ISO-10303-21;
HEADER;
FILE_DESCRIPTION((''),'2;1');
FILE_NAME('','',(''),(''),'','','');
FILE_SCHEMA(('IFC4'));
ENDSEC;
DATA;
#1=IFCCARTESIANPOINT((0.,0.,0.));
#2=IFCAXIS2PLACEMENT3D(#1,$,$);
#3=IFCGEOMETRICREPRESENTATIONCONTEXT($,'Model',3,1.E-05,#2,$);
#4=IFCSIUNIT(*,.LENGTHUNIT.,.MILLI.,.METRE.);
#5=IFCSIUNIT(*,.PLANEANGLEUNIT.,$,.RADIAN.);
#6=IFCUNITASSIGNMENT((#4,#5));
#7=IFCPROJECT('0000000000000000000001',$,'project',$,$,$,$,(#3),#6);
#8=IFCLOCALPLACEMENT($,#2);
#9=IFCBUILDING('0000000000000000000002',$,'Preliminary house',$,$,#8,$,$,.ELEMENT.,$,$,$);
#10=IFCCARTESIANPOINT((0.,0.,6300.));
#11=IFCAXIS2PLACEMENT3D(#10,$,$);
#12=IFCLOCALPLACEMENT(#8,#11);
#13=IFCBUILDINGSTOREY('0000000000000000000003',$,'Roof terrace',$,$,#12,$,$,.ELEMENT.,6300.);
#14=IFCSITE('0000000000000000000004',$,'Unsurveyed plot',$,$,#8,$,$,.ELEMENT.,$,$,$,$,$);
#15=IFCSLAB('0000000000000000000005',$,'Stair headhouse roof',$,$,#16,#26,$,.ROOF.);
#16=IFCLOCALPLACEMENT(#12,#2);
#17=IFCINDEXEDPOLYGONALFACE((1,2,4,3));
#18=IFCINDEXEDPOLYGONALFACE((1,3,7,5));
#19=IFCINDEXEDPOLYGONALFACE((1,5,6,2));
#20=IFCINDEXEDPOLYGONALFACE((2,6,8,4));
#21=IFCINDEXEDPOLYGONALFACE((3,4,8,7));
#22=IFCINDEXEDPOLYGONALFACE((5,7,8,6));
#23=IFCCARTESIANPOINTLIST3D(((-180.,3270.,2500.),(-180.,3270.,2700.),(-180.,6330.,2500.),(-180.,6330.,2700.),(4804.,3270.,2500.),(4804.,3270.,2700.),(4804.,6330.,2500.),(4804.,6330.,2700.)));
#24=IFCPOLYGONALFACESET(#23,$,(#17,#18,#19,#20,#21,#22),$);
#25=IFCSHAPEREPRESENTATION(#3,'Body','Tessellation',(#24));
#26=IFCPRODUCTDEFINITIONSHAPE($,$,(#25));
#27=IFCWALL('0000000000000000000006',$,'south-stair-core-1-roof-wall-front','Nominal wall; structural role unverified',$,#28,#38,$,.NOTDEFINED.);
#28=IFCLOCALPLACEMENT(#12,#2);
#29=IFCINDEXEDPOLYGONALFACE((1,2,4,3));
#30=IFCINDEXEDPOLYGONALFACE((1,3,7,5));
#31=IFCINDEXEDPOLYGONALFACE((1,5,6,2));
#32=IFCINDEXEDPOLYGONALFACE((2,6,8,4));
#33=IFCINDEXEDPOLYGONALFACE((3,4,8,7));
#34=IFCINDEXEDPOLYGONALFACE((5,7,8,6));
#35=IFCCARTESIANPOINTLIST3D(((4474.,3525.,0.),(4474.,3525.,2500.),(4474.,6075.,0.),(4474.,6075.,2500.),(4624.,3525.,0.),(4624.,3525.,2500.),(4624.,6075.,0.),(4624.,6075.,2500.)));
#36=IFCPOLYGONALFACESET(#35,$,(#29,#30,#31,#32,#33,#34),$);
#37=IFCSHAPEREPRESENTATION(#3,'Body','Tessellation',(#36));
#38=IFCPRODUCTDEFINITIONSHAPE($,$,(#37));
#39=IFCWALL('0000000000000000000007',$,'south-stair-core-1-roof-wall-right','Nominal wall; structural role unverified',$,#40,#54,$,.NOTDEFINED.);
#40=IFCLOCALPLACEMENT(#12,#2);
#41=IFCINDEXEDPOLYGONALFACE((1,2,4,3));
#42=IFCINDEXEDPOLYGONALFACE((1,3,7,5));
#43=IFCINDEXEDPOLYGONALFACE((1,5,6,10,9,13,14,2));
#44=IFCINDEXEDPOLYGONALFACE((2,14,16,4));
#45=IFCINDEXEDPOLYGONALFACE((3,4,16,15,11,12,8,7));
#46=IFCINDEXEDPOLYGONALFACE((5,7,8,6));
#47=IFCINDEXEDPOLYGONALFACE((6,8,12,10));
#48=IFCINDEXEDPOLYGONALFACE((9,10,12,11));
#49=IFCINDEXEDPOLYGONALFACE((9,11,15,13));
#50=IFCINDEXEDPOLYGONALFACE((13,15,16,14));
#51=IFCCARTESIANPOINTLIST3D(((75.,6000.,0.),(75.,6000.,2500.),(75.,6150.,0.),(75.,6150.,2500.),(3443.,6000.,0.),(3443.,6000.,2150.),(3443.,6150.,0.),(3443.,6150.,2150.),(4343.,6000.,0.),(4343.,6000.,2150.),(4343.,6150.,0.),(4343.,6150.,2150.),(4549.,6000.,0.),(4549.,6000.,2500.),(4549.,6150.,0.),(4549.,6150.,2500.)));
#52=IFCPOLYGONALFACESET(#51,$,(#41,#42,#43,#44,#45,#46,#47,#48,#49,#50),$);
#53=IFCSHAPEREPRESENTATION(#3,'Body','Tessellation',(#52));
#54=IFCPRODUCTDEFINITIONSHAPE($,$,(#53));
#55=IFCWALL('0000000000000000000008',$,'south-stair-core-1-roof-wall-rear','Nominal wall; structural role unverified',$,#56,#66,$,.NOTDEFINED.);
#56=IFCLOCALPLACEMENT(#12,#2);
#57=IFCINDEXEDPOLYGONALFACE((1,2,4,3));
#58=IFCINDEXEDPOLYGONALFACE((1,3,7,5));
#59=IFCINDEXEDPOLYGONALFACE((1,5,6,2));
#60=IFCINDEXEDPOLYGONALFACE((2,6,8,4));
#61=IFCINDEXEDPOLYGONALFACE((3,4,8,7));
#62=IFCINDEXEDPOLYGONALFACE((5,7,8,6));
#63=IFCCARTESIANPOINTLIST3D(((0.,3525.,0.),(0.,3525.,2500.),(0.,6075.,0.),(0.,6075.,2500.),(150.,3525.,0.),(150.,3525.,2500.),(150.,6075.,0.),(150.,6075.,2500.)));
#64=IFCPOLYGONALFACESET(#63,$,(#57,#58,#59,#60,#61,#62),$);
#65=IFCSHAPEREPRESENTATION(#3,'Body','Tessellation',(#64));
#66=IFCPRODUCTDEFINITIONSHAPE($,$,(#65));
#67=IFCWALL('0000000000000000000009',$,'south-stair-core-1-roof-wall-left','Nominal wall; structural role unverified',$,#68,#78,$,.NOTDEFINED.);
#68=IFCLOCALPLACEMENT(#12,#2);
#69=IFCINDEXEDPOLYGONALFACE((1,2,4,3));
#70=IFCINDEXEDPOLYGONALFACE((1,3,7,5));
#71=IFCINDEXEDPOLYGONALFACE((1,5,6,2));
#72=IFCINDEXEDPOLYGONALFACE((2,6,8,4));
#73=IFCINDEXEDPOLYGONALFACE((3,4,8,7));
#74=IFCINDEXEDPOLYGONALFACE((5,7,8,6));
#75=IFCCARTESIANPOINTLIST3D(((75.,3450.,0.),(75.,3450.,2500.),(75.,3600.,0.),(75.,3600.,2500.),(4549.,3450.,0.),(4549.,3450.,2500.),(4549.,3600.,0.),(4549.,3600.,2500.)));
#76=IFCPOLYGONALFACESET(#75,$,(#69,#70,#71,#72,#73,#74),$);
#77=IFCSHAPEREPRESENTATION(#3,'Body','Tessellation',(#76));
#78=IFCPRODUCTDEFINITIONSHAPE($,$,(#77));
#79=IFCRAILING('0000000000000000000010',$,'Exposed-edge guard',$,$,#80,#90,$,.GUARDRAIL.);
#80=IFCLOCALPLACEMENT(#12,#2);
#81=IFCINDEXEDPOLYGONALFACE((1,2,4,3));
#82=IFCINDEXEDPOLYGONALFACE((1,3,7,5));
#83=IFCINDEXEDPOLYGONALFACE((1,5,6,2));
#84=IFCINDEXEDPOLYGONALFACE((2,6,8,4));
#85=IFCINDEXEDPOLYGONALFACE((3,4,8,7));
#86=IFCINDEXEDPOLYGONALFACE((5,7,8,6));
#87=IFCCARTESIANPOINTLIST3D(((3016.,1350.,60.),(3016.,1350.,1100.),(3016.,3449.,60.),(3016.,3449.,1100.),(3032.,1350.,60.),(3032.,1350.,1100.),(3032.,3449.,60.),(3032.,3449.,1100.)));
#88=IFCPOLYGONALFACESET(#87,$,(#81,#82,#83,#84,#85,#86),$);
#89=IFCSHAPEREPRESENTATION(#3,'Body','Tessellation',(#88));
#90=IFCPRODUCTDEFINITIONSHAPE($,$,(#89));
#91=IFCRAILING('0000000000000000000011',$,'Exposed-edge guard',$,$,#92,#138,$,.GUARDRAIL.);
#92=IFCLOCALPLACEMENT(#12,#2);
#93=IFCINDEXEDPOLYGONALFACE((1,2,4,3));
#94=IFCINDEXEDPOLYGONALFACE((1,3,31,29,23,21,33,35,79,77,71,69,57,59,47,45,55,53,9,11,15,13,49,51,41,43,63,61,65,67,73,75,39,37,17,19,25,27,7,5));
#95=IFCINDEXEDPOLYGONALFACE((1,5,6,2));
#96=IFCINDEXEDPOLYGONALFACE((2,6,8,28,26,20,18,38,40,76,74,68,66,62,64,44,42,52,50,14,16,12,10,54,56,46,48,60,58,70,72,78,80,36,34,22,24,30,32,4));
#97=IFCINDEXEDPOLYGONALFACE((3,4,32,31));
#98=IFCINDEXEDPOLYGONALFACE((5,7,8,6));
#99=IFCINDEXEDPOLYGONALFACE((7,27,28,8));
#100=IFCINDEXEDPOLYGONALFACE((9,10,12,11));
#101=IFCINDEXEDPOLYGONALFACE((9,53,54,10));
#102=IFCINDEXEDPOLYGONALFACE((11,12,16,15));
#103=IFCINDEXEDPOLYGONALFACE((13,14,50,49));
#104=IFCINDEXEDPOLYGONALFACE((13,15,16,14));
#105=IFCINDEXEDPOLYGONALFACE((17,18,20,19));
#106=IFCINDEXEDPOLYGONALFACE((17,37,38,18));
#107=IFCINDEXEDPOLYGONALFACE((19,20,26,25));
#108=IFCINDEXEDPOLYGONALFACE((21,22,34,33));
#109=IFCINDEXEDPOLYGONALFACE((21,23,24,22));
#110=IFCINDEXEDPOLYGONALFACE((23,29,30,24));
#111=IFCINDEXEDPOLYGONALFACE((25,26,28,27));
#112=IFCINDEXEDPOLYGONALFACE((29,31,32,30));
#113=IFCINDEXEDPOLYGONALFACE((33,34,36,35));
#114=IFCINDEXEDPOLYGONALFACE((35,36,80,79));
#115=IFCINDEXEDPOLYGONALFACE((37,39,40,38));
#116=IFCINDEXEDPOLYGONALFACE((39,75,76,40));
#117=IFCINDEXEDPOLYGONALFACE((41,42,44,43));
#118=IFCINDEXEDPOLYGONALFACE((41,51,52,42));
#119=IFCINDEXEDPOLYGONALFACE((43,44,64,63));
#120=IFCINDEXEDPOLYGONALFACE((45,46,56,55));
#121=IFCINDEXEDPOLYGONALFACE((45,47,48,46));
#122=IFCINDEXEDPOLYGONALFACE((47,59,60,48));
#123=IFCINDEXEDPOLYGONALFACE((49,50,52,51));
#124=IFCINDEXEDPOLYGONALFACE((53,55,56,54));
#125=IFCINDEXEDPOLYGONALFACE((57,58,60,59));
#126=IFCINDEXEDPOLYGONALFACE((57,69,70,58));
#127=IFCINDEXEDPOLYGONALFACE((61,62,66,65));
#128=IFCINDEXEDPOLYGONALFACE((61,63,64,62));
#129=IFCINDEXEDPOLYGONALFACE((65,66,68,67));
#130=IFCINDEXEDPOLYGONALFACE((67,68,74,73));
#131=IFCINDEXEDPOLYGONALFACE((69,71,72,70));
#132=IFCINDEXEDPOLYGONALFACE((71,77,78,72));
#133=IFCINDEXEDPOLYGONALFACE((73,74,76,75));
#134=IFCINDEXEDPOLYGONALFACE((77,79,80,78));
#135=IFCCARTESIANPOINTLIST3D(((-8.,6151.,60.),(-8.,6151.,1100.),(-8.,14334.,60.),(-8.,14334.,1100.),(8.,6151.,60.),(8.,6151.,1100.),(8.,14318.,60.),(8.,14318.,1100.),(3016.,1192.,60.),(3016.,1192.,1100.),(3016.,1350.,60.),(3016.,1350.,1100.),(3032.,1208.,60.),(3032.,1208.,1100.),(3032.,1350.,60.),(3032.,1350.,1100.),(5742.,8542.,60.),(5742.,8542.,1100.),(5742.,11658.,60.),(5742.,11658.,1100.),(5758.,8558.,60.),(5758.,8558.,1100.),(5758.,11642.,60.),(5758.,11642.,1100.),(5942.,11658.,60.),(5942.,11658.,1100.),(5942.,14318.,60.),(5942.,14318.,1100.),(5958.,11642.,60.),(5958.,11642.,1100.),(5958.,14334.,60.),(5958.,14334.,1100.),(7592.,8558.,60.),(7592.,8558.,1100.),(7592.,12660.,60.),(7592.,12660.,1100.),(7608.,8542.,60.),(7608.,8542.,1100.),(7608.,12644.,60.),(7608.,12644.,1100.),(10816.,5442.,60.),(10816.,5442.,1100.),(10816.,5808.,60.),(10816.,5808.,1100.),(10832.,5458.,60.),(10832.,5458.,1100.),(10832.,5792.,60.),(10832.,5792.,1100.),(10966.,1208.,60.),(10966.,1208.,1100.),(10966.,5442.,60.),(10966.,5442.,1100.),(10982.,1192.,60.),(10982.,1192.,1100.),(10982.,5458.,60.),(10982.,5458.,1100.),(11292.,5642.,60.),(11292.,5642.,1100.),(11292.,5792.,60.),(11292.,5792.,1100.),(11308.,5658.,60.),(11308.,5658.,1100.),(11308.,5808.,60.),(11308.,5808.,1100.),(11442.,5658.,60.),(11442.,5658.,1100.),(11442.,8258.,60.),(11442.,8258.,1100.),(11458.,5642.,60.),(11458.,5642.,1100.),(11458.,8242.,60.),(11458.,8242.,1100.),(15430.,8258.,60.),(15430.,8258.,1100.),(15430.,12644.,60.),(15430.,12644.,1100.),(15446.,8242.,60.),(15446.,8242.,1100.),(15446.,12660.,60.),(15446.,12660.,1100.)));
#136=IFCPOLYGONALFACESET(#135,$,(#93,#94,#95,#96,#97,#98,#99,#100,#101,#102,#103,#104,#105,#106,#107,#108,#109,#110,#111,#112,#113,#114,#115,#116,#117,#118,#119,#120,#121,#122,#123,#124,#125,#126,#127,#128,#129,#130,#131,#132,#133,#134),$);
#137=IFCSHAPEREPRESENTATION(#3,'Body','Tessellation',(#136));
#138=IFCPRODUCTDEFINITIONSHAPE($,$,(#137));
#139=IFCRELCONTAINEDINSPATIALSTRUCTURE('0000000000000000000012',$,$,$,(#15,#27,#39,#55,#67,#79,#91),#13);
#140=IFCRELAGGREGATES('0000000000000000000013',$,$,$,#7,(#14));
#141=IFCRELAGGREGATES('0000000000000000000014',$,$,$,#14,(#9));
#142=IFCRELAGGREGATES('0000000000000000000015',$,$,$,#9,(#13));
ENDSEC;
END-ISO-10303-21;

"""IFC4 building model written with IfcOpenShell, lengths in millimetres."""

from ifc_helpers import new_model, si_unit, frame, origin, place, context, project, spatial, polyline, outline, extrude, element, save


model = new_model("IFC4")

# Units and contexts
model_context = context("Model", 3, precision=1e-05, world=origin())
ifc_project = project(units=[si_unit("LENGTHUNIT", "METRE", prefix="MILLI"), si_unit("PLANEANGLEUNIT", "RADIAN")], contexts=[model_context])

# Site, building, storey
placement_1 = place(None, origin())
site = spatial("IfcSite", under=ifc_project, at=placement_1, Name="Unsurveyed plot", CompositionType="ELEMENT")
building = spatial("IfcBuilding", under=site, at=placement_1, Name="Preliminary house", CompositionType="ELEMENT")
placement_2 = place(placement_1, frame((0.0, 0.0, 6300.0)))
storey = spatial("IfcBuildingStorey", under=building, at=placement_2, Name="Roof terrace", CompositionType="ELEMENT", Elevation=6300.0)

# Slab
element("IfcSlab", 1, at=placement_2, inside=storey, Name="Stair headhouse roof", PredefinedType="ROOF", context=model_context, shape_type="SweptSolid", body=[
    extrude(outline(polyline([(4804.0, 3270.0), (-180.0, 3270.0), (-180.0, 6330.0), (4804.0, 6330.0), (4804.0, 3270.0)])), frame((0.0, 0.0, 2500.0)), (0.0, 0.0, 1.0), 200.0),
])

# Wall
element("IfcWall", 2, at=placement_2, inside=storey, Name="south-stair-core-1-roof-wall-front", Description="Nominal wall; structural role unverified", PredefinedType="NOTDEFINED", context=model_context, shape_type="SweptSolid", body=[
    extrude(outline(polyline([(4474.0, 6075.0), (4624.0, 6075.0), (4624.0, 3525.0), (4474.0, 3525.0), (4474.0, 6075.0)])), origin(), (0.0, 0.0, 1.0), 2500.0),
])

# Wall, opening
wall_1 = element("IfcWall", 3, at=placement_2, inside=storey, Name="south-stair-core-1-roof-wall-right", Description="Nominal wall; structural role unverified", PredefinedType="NOTDEFINED", context=model_context, shape_type="SweptSolid", body=[
    extrude(outline(polyline([(75.0, 6000.0), (75.0, 6150.0), (4549.0, 6150.0), (4549.0, 6000.0), (75.0, 6000.0)])), origin(), (0.0, 0.0, 1.0), 2500.0),
])
element("IfcOpeningElement", 4, at=placement_2, cuts=wall_1, PredefinedType="OPENING", context=model_context, shape_type="SweptSolid", body=[
    extrude(outline(polyline([(4343.0, 6525.0), (3443.0, 6525.0), (3443.0, 5625.0), (4343.0, 5625.0), (4343.0, 6525.0)])), origin(), (0.0, 0.0, 1.0), 2150.0),
])

# Walls
element("IfcWall", 5, at=placement_2, inside=storey, Name="south-stair-core-1-roof-wall-rear", Description="Nominal wall; structural role unverified", PredefinedType="NOTDEFINED", context=model_context, shape_type="SweptSolid", body=[
    extrude(outline(polyline([(0.0, 6075.0), (150.0, 6075.0), (150.0, 3525.0), (0.0, 3525.0), (0.0, 6075.0)])), origin(), (0.0, 0.0, 1.0), 2500.0),
])
element("IfcWall", 6, at=placement_2, inside=storey, Name="south-stair-core-1-roof-wall-left", Description="Nominal wall; structural role unverified", PredefinedType="NOTDEFINED", context=model_context, shape_type="SweptSolid", body=[
    extrude(outline(polyline([(75.0, 3450.0), (75.0, 3600.0), (4549.0, 3600.0), (4549.0, 3450.0), (75.0, 3450.0)])), origin(), (0.0, 0.0, 1.0), 2500.0),
])

# Railings
element("IfcRailing", 7, at=placement_2, inside=storey, Name="Exposed-edge guard", PredefinedType="GUARDRAIL", context=model_context, shape_type="SweptSolid", body=[
    extrude(outline(polyline([(3016.0, 3449.0), (3032.0, 3449.0), (3032.0, 1350.0), (3016.0, 1350.0), (3016.0, 3449.0)])), frame((0.0, 0.0, 60.0)), (0.0, 0.0, 1.0), 1040.0),
])
element("IfcRailing", 8, at=placement_2, inside=storey, Name="Exposed-edge guard", PredefinedType="GUARDRAIL", context=model_context, shape_type="SweptSolid", body=[
    extrude(outline(polyline([(-8.0, 14334.0), (5958.0, 14334.0), (5958.0, 11642.0), (5758.0, 11642.0), (5758.0, 8558.0), (7592.0, 8558.0), (7592.0, 12660.0), (15446.0, 12660.0), (15446.0, 8242.0), (11458.0, 8242.0), (11458.0, 5642.0), (11292.0, 5642.0), (11292.0, 5792.0), (10832.0, 5792.0), (10832.0, 5458.0), (10982.0, 5458.0), (10982.0, 1192.0), (3016.0, 1192.0), (3016.0, 1350.0), (3032.0, 1350.0), (3032.0, 1208.0), (10966.0, 1208.0), (10966.0, 5442.0), (10816.0, 5442.0), (10816.0, 5808.0), (11308.0, 5808.0), (11308.0, 5658.0), (11442.0, 5658.0), (11442.0, 8258.0), (15430.0, 8258.0), (15430.0, 12644.0), (7608.0, 12644.0), (7608.0, 8542.0), (5742.0, 8542.0), (5742.0, 11658.0), (5942.0, 11658.0), (5942.0, 14318.0), (8.0, 14318.0), (8.0, 6151.0), (-8.0, 6151.0), (-8.0, 14334.0)])), frame((0.0, 0.0, 60.0)), (0.0, 0.0, 1.0), 1040.0),
])

save(model, "model.ifc")
